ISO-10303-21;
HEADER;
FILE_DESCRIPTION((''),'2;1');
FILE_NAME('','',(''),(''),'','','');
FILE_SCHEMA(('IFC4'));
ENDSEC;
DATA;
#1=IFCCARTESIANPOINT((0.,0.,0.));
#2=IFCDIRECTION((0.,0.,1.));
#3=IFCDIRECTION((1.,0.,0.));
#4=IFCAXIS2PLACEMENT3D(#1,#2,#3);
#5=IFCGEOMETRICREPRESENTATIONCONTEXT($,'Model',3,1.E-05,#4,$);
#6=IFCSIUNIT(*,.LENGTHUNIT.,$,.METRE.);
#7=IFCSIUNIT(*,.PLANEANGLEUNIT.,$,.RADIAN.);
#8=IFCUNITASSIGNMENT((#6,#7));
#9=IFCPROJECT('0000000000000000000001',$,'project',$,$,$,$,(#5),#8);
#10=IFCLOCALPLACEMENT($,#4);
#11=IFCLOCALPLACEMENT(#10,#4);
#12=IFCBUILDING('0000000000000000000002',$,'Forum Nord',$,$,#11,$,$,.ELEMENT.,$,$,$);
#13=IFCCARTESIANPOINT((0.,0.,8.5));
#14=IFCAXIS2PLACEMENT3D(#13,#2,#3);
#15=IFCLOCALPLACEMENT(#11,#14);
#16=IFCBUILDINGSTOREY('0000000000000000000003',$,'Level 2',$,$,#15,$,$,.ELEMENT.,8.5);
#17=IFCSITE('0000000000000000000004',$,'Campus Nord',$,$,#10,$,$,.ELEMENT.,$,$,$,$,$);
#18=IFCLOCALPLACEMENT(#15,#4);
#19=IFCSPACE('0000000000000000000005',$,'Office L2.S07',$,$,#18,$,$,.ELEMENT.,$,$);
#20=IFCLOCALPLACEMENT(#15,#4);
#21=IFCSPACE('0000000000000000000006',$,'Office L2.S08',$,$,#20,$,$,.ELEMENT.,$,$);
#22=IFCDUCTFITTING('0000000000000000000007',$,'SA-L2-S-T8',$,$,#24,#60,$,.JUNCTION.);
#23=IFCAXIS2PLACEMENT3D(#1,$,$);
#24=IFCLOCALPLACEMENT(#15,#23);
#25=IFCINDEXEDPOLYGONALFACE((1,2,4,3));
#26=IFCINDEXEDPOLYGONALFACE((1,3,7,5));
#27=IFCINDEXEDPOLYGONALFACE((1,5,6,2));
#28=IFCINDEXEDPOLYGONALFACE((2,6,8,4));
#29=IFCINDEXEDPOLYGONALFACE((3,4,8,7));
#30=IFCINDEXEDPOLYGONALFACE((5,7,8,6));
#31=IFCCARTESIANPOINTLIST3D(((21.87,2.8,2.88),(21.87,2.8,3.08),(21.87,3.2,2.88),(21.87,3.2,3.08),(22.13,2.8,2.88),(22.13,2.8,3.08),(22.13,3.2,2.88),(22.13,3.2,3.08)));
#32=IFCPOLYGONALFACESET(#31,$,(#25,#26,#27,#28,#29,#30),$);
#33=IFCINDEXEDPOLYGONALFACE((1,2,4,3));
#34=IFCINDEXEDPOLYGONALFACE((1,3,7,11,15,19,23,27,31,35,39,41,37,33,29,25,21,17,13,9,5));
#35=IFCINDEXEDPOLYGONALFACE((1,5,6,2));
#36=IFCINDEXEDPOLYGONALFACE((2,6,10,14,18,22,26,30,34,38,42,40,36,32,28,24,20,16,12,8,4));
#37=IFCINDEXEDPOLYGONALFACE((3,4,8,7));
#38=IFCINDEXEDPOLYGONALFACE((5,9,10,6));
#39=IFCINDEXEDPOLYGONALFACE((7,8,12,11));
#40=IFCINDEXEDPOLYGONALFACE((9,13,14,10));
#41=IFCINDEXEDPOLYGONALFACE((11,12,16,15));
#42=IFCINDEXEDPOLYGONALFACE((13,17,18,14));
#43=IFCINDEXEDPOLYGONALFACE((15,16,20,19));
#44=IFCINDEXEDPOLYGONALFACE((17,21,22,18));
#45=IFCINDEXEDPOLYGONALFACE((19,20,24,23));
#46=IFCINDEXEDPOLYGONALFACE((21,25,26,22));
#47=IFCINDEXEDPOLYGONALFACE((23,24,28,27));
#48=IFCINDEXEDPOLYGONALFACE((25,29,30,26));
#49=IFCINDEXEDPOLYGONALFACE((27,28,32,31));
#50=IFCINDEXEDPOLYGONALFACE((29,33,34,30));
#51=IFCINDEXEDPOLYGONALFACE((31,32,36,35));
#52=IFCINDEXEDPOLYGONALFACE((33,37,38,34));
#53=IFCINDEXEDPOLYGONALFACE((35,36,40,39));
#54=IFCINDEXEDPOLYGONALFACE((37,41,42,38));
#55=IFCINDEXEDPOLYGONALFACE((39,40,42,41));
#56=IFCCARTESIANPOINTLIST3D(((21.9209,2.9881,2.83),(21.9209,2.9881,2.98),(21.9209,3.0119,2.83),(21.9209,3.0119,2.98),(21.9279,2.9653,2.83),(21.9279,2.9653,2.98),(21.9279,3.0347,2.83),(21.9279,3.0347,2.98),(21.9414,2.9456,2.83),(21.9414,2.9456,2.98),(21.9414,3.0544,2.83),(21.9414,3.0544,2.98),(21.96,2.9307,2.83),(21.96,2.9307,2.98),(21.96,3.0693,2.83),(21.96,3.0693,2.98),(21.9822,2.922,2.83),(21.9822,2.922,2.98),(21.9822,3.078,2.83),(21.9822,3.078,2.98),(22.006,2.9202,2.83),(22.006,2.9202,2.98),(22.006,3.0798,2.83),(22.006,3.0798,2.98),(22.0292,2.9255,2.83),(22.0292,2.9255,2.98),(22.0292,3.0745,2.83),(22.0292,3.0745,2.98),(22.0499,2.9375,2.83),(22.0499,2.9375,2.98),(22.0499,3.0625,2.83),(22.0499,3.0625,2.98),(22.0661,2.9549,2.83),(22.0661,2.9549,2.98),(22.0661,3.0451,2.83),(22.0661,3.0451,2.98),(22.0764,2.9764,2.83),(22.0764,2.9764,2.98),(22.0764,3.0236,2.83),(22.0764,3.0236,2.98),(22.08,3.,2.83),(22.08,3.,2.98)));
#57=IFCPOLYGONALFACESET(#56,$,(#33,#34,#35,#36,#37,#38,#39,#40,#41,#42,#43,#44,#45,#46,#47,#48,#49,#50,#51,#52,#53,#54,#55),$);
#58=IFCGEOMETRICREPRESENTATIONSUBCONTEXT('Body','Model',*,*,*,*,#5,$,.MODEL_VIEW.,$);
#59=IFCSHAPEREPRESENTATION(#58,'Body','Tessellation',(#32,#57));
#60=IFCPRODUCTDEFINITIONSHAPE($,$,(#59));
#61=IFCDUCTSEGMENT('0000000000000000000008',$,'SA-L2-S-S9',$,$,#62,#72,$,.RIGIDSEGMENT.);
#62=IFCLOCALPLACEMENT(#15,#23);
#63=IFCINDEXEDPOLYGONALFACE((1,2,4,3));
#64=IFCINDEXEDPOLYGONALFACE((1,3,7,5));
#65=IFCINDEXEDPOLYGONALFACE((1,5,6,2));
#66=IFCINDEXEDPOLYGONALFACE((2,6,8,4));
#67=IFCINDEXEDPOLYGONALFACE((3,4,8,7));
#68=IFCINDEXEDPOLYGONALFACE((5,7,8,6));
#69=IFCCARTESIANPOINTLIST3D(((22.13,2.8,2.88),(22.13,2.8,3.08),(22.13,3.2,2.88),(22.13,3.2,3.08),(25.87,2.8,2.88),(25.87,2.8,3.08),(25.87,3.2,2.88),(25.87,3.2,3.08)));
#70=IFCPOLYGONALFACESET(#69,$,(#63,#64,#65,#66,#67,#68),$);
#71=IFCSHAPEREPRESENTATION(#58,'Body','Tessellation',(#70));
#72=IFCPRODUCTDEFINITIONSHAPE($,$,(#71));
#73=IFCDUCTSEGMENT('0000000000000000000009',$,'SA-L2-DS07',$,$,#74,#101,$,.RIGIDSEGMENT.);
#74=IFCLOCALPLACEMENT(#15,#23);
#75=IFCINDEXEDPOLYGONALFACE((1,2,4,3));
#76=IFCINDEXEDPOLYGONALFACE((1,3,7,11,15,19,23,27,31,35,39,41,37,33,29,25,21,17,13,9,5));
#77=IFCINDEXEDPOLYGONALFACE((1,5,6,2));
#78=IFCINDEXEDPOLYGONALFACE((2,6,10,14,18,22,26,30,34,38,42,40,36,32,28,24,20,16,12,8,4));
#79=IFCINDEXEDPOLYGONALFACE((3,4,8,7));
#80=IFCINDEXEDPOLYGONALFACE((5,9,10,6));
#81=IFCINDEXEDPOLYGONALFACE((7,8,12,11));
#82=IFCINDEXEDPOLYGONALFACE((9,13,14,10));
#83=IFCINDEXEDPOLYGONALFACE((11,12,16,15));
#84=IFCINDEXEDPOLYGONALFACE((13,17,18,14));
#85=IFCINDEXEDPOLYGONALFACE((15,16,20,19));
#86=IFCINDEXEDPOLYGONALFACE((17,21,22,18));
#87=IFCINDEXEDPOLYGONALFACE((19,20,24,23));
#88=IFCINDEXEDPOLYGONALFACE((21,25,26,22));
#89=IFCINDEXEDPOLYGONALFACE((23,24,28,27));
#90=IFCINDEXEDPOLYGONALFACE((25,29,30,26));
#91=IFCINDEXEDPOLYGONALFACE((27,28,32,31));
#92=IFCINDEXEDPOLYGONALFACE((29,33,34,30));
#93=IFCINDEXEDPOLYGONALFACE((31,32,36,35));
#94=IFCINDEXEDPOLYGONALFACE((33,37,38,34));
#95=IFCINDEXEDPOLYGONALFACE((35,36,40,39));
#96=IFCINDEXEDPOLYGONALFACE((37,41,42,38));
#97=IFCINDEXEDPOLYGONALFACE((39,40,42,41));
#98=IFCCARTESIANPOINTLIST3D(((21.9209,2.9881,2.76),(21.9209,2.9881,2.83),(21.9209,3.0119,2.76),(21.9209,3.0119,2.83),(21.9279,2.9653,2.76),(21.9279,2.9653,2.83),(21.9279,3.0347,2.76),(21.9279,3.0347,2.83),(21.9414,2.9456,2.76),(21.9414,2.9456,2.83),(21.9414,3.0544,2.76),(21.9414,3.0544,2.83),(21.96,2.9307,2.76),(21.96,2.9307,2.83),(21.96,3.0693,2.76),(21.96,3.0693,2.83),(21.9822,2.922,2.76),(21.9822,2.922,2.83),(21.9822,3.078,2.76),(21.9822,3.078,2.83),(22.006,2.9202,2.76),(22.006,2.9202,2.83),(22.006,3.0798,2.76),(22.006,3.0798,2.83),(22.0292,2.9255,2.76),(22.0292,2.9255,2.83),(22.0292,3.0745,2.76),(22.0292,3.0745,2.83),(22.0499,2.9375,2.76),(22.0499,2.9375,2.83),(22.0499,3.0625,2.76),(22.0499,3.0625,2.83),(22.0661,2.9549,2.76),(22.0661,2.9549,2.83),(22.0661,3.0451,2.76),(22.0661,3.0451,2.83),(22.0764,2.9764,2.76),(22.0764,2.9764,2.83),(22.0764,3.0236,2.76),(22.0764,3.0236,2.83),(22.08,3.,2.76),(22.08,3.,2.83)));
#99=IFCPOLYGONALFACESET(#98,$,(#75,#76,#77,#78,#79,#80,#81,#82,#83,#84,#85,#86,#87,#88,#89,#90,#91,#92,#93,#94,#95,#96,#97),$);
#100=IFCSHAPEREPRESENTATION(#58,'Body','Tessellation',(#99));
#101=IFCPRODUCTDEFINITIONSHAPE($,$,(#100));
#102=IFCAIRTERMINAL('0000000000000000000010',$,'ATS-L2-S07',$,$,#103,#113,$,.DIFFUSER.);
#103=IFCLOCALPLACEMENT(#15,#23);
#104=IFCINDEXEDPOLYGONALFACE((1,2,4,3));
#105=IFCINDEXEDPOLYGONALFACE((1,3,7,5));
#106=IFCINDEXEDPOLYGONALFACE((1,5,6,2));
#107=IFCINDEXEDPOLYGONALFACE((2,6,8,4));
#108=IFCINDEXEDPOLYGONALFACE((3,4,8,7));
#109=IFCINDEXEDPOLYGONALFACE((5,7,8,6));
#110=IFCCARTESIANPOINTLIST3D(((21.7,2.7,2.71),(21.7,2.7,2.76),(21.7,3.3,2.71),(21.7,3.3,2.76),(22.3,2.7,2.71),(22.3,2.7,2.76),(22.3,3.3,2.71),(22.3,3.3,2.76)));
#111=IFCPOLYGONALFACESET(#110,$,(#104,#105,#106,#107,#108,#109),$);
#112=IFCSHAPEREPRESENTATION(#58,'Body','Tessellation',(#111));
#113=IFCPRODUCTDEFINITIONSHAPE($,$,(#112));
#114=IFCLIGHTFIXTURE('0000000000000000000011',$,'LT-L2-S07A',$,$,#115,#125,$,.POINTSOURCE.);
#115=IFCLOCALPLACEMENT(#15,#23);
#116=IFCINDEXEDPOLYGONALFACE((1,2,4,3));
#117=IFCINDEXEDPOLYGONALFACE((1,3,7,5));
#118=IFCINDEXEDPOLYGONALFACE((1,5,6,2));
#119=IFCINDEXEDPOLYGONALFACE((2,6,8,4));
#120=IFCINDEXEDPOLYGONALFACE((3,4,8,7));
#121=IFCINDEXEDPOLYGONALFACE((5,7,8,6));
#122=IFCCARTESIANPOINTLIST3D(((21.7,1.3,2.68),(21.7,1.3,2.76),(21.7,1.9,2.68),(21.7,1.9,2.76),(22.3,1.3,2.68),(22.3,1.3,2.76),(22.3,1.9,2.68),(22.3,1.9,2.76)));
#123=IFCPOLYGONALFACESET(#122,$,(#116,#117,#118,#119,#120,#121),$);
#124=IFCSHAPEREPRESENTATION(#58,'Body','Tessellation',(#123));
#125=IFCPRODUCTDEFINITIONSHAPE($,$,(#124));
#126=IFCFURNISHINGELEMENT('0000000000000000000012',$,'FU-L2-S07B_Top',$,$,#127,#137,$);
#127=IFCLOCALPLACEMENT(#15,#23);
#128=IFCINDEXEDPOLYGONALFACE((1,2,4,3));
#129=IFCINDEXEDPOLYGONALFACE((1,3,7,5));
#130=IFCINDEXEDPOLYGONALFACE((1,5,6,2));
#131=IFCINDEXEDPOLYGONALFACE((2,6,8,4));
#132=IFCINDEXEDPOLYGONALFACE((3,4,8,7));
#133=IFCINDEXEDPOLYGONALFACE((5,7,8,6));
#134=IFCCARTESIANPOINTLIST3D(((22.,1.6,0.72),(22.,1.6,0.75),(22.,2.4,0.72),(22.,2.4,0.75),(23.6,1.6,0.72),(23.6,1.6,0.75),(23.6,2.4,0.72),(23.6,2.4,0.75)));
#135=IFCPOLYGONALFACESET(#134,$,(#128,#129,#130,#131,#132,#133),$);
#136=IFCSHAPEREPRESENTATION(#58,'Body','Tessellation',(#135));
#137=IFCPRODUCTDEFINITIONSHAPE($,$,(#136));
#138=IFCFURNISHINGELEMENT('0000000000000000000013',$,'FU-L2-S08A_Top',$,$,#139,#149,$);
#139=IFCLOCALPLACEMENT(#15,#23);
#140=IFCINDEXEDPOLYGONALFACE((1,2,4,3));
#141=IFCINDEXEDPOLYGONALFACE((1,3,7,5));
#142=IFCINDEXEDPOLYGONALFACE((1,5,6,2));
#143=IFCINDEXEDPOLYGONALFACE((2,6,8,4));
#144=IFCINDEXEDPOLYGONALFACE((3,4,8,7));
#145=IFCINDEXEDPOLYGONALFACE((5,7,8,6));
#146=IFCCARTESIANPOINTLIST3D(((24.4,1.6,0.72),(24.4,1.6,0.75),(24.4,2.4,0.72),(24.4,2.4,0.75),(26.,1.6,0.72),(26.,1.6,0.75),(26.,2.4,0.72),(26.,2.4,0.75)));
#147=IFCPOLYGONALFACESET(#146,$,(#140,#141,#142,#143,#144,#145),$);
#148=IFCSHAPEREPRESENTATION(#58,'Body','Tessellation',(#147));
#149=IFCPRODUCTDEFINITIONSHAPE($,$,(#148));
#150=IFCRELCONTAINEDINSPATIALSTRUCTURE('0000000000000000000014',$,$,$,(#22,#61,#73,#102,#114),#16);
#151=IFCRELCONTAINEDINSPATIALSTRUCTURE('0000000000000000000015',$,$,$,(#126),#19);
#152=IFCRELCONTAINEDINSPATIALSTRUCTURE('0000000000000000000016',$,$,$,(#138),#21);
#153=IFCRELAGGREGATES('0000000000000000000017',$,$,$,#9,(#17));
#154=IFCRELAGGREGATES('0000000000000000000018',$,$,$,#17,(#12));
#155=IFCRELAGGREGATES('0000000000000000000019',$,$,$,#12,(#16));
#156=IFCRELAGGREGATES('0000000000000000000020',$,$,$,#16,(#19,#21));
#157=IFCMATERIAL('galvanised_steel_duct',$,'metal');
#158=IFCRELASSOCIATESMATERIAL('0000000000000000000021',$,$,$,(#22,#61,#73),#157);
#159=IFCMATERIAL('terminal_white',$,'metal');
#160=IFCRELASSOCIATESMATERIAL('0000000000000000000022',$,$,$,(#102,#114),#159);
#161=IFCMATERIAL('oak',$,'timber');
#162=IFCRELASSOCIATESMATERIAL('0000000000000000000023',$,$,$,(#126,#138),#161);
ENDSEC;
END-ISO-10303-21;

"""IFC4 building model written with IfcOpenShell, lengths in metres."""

from ifc_helpers import new_model, si_unit, frame, frame_2d, origin_with_axes, origin_2d_with_axis, place, context, subcontext, project, spatial, rectangle, circle, extrude, material, element, save


model = new_model("IFC4")

# Units and contexts
model_context = context("Model", 3, precision=1e-05, world=origin_with_axes())
body_context = subcontext(model_context, "Body", "Model", "MODEL_VIEW")
ifc_project = project(units=[si_unit("LENGTHUNIT", "METRE"), si_unit("PLANEANGLEUNIT", "RADIAN")], contexts=[model_context])

# Site, building, storey
site_placement = place(None, origin_with_axes())
site = spatial("IfcSite", under=ifc_project, at=site_placement, Name="Campus Nord", CompositionType="ELEMENT")
building_placement = place(site_placement, origin_with_axes())
building = spatial("IfcBuilding", under=site, at=building_placement, Name="Forum Nord", CompositionType="ELEMENT")
storey_placement = place(building_placement, frame((0.0, 0.0, 8.5), z_axis=(0.0, 0.0, 1.0), x_axis=(1.0, 0.0, 0.0)))
storey = spatial("IfcBuildingStorey", under=building, at=storey_placement, Name="Level 2", CompositionType="ELEMENT", Elevation=8.5)

# Duct fitting
ifc_material_1 = material(Name="galvanised_steel_duct", Category="metal")
duct_fitting_placement = place(storey_placement, frame((21.87, 3.0, 2.98), z_axis=(1.0, 0.0, 0.0), x_axis=(0.0, 1.0, 0.0)))
element("IfcDuctFitting", 1, at=duct_fitting_placement, inside=storey, material=ifc_material_1, Name="SA-L2-S-T8", PredefinedType="JUNCTION", context=body_context, shape_type="SweptSolid", body=[
    extrude(rectangle(XDim=0.4, YDim=0.2, at=origin_2d_with_axis()), origin_with_axes(), (0.0, 0.0, 1.0), 0.26),
    extrude(circle(Radius=0.08, at=origin_2d_with_axis()), frame((0.0, 0.0, 0.13), z_axis=(0.0, -1.0, 0.0), x_axis=(0.0, 0.0, 1.0)), (0.0, 0.0, 1.0), 0.15),
])

# Duct segments
duct_segment_1_placement = place(storey_placement, frame((22.13, 3.0, 2.98), z_axis=(1.0, 0.0, 0.0), x_axis=(0.0, 1.0, 0.0)))
element("IfcDuctSegment", 2, at=duct_segment_1_placement, inside=storey, material=ifc_material_1, Name="SA-L2-S-S9", PredefinedType="RIGIDSEGMENT", context=body_context, shape_type="SweptSolid", body=[
    extrude(rectangle(XDim=0.4, YDim=0.2, at=origin_2d_with_axis()), origin_with_axes(), (0.0, 0.0, 1.0), 3.74),
])
duct_segment_2_placement = place(storey_placement, frame((22.0, 3.0, 2.83), z_axis=(0.0, 0.0, -1.0), x_axis=(1.0, 0.0, 0.0)))
element("IfcDuctSegment", 3, at=duct_segment_2_placement, inside=storey, material=ifc_material_1, Name="SA-L2-DS07", PredefinedType="RIGIDSEGMENT", context=body_context, shape_type="SweptSolid", body=[
    extrude(circle(Radius=0.08, at=origin_2d_with_axis()), origin_with_axes(), (0.0, 0.0, 1.0), 0.07),
])

# Air terminal
ifc_material_2 = material(Name="terminal_white", Category="metal")
air_terminal_placement = place(storey_placement, frame((22.0, 3.0, 2.71), z_axis=(0.0, 0.0, 1.0), x_axis=(1.0, 0.0, 0.0)))
element("IfcAirTerminal", 4, at=air_terminal_placement, inside=storey, material=ifc_material_2, Name="ATS-L2-S07", PredefinedType="DIFFUSER", context=body_context, shape_type="SweptSolid", body=[
    extrude(rectangle(XDim=0.6, YDim=0.6, at=origin_2d_with_axis()), origin_with_axes(), (0.0, 0.0, 1.0), 0.05),
])

# Light fixture
light_fixture_placement = place(storey_placement, frame((22.0, 1.6, 2.68), z_axis=(0.0, 0.0, 1.0), x_axis=(1.0, 0.0, 0.0)))
element("IfcLightFixture", 5, at=light_fixture_placement, inside=storey, material=ifc_material_2, Name="LT-L2-S07A", PredefinedType="POINTSOURCE", context=body_context, shape_type="SweptSolid", body=[
    extrude(rectangle(XDim=0.6, YDim=0.6, at=origin_2d_with_axis()), origin_with_axes(), (0.0, 0.0, 1.0), 0.08),
])

# Shared definitions
space_1_placement = place(storey_placement, origin_with_axes())
space_1 = spatial("IfcSpace", under=storey, at=space_1_placement, Name="Office L2.S07", CompositionType="ELEMENT")

# Furnishing element
ifc_material_3 = material(Name="oak", Category="timber")
furnishing_1_placement = place(storey_placement, frame((22.0, 1.0, 0.0), z_axis=(0.0, 0.0, 1.0), x_axis=(1.0, 0.0, 0.0)))
element("IfcFurnishingElement", 6, at=furnishing_1_placement, inside=space_1, material=ifc_material_3, Name="FU-L2-S07B_Top", context=body_context, shape_type="SweptSolid", body=[
    extrude(rectangle(XDim=1.6, YDim=0.8, at=frame_2d((0.8, 1.0), x_axis=(1.0, 0.0))), frame((0.0, 0.0, 0.72), z_axis=(0.0, 0.0, 1.0), x_axis=(1.0, 0.0, 0.0)), (0.0, 0.0, 1.0), 0.03),
])

# Shared definitions
space_2_placement = place(storey_placement, origin_with_axes())
space_2 = spatial("IfcSpace", under=storey, at=space_2_placement, Name="Office L2.S08", CompositionType="ELEMENT")

# Furnishing element
furnishing_2_placement = place(storey_placement, frame((24.4, 1.0, 0.0), z_axis=(0.0, 0.0, 1.0), x_axis=(1.0, 0.0, 0.0)))
element("IfcFurnishingElement", 7, at=furnishing_2_placement, inside=space_2, material=ifc_material_3, Name="FU-L2-S08A_Top", context=body_context, shape_type="SweptSolid", body=[
    extrude(rectangle(XDim=1.6, YDim=0.8, at=frame_2d((0.8, 1.0), x_axis=(1.0, 0.0))), frame((0.0, 0.0, 0.72), z_axis=(0.0, 0.0, 1.0), x_axis=(1.0, 0.0, 0.0)), (0.0, 0.0, 1.0), 0.03),
])

save(model, "model.ifc")
